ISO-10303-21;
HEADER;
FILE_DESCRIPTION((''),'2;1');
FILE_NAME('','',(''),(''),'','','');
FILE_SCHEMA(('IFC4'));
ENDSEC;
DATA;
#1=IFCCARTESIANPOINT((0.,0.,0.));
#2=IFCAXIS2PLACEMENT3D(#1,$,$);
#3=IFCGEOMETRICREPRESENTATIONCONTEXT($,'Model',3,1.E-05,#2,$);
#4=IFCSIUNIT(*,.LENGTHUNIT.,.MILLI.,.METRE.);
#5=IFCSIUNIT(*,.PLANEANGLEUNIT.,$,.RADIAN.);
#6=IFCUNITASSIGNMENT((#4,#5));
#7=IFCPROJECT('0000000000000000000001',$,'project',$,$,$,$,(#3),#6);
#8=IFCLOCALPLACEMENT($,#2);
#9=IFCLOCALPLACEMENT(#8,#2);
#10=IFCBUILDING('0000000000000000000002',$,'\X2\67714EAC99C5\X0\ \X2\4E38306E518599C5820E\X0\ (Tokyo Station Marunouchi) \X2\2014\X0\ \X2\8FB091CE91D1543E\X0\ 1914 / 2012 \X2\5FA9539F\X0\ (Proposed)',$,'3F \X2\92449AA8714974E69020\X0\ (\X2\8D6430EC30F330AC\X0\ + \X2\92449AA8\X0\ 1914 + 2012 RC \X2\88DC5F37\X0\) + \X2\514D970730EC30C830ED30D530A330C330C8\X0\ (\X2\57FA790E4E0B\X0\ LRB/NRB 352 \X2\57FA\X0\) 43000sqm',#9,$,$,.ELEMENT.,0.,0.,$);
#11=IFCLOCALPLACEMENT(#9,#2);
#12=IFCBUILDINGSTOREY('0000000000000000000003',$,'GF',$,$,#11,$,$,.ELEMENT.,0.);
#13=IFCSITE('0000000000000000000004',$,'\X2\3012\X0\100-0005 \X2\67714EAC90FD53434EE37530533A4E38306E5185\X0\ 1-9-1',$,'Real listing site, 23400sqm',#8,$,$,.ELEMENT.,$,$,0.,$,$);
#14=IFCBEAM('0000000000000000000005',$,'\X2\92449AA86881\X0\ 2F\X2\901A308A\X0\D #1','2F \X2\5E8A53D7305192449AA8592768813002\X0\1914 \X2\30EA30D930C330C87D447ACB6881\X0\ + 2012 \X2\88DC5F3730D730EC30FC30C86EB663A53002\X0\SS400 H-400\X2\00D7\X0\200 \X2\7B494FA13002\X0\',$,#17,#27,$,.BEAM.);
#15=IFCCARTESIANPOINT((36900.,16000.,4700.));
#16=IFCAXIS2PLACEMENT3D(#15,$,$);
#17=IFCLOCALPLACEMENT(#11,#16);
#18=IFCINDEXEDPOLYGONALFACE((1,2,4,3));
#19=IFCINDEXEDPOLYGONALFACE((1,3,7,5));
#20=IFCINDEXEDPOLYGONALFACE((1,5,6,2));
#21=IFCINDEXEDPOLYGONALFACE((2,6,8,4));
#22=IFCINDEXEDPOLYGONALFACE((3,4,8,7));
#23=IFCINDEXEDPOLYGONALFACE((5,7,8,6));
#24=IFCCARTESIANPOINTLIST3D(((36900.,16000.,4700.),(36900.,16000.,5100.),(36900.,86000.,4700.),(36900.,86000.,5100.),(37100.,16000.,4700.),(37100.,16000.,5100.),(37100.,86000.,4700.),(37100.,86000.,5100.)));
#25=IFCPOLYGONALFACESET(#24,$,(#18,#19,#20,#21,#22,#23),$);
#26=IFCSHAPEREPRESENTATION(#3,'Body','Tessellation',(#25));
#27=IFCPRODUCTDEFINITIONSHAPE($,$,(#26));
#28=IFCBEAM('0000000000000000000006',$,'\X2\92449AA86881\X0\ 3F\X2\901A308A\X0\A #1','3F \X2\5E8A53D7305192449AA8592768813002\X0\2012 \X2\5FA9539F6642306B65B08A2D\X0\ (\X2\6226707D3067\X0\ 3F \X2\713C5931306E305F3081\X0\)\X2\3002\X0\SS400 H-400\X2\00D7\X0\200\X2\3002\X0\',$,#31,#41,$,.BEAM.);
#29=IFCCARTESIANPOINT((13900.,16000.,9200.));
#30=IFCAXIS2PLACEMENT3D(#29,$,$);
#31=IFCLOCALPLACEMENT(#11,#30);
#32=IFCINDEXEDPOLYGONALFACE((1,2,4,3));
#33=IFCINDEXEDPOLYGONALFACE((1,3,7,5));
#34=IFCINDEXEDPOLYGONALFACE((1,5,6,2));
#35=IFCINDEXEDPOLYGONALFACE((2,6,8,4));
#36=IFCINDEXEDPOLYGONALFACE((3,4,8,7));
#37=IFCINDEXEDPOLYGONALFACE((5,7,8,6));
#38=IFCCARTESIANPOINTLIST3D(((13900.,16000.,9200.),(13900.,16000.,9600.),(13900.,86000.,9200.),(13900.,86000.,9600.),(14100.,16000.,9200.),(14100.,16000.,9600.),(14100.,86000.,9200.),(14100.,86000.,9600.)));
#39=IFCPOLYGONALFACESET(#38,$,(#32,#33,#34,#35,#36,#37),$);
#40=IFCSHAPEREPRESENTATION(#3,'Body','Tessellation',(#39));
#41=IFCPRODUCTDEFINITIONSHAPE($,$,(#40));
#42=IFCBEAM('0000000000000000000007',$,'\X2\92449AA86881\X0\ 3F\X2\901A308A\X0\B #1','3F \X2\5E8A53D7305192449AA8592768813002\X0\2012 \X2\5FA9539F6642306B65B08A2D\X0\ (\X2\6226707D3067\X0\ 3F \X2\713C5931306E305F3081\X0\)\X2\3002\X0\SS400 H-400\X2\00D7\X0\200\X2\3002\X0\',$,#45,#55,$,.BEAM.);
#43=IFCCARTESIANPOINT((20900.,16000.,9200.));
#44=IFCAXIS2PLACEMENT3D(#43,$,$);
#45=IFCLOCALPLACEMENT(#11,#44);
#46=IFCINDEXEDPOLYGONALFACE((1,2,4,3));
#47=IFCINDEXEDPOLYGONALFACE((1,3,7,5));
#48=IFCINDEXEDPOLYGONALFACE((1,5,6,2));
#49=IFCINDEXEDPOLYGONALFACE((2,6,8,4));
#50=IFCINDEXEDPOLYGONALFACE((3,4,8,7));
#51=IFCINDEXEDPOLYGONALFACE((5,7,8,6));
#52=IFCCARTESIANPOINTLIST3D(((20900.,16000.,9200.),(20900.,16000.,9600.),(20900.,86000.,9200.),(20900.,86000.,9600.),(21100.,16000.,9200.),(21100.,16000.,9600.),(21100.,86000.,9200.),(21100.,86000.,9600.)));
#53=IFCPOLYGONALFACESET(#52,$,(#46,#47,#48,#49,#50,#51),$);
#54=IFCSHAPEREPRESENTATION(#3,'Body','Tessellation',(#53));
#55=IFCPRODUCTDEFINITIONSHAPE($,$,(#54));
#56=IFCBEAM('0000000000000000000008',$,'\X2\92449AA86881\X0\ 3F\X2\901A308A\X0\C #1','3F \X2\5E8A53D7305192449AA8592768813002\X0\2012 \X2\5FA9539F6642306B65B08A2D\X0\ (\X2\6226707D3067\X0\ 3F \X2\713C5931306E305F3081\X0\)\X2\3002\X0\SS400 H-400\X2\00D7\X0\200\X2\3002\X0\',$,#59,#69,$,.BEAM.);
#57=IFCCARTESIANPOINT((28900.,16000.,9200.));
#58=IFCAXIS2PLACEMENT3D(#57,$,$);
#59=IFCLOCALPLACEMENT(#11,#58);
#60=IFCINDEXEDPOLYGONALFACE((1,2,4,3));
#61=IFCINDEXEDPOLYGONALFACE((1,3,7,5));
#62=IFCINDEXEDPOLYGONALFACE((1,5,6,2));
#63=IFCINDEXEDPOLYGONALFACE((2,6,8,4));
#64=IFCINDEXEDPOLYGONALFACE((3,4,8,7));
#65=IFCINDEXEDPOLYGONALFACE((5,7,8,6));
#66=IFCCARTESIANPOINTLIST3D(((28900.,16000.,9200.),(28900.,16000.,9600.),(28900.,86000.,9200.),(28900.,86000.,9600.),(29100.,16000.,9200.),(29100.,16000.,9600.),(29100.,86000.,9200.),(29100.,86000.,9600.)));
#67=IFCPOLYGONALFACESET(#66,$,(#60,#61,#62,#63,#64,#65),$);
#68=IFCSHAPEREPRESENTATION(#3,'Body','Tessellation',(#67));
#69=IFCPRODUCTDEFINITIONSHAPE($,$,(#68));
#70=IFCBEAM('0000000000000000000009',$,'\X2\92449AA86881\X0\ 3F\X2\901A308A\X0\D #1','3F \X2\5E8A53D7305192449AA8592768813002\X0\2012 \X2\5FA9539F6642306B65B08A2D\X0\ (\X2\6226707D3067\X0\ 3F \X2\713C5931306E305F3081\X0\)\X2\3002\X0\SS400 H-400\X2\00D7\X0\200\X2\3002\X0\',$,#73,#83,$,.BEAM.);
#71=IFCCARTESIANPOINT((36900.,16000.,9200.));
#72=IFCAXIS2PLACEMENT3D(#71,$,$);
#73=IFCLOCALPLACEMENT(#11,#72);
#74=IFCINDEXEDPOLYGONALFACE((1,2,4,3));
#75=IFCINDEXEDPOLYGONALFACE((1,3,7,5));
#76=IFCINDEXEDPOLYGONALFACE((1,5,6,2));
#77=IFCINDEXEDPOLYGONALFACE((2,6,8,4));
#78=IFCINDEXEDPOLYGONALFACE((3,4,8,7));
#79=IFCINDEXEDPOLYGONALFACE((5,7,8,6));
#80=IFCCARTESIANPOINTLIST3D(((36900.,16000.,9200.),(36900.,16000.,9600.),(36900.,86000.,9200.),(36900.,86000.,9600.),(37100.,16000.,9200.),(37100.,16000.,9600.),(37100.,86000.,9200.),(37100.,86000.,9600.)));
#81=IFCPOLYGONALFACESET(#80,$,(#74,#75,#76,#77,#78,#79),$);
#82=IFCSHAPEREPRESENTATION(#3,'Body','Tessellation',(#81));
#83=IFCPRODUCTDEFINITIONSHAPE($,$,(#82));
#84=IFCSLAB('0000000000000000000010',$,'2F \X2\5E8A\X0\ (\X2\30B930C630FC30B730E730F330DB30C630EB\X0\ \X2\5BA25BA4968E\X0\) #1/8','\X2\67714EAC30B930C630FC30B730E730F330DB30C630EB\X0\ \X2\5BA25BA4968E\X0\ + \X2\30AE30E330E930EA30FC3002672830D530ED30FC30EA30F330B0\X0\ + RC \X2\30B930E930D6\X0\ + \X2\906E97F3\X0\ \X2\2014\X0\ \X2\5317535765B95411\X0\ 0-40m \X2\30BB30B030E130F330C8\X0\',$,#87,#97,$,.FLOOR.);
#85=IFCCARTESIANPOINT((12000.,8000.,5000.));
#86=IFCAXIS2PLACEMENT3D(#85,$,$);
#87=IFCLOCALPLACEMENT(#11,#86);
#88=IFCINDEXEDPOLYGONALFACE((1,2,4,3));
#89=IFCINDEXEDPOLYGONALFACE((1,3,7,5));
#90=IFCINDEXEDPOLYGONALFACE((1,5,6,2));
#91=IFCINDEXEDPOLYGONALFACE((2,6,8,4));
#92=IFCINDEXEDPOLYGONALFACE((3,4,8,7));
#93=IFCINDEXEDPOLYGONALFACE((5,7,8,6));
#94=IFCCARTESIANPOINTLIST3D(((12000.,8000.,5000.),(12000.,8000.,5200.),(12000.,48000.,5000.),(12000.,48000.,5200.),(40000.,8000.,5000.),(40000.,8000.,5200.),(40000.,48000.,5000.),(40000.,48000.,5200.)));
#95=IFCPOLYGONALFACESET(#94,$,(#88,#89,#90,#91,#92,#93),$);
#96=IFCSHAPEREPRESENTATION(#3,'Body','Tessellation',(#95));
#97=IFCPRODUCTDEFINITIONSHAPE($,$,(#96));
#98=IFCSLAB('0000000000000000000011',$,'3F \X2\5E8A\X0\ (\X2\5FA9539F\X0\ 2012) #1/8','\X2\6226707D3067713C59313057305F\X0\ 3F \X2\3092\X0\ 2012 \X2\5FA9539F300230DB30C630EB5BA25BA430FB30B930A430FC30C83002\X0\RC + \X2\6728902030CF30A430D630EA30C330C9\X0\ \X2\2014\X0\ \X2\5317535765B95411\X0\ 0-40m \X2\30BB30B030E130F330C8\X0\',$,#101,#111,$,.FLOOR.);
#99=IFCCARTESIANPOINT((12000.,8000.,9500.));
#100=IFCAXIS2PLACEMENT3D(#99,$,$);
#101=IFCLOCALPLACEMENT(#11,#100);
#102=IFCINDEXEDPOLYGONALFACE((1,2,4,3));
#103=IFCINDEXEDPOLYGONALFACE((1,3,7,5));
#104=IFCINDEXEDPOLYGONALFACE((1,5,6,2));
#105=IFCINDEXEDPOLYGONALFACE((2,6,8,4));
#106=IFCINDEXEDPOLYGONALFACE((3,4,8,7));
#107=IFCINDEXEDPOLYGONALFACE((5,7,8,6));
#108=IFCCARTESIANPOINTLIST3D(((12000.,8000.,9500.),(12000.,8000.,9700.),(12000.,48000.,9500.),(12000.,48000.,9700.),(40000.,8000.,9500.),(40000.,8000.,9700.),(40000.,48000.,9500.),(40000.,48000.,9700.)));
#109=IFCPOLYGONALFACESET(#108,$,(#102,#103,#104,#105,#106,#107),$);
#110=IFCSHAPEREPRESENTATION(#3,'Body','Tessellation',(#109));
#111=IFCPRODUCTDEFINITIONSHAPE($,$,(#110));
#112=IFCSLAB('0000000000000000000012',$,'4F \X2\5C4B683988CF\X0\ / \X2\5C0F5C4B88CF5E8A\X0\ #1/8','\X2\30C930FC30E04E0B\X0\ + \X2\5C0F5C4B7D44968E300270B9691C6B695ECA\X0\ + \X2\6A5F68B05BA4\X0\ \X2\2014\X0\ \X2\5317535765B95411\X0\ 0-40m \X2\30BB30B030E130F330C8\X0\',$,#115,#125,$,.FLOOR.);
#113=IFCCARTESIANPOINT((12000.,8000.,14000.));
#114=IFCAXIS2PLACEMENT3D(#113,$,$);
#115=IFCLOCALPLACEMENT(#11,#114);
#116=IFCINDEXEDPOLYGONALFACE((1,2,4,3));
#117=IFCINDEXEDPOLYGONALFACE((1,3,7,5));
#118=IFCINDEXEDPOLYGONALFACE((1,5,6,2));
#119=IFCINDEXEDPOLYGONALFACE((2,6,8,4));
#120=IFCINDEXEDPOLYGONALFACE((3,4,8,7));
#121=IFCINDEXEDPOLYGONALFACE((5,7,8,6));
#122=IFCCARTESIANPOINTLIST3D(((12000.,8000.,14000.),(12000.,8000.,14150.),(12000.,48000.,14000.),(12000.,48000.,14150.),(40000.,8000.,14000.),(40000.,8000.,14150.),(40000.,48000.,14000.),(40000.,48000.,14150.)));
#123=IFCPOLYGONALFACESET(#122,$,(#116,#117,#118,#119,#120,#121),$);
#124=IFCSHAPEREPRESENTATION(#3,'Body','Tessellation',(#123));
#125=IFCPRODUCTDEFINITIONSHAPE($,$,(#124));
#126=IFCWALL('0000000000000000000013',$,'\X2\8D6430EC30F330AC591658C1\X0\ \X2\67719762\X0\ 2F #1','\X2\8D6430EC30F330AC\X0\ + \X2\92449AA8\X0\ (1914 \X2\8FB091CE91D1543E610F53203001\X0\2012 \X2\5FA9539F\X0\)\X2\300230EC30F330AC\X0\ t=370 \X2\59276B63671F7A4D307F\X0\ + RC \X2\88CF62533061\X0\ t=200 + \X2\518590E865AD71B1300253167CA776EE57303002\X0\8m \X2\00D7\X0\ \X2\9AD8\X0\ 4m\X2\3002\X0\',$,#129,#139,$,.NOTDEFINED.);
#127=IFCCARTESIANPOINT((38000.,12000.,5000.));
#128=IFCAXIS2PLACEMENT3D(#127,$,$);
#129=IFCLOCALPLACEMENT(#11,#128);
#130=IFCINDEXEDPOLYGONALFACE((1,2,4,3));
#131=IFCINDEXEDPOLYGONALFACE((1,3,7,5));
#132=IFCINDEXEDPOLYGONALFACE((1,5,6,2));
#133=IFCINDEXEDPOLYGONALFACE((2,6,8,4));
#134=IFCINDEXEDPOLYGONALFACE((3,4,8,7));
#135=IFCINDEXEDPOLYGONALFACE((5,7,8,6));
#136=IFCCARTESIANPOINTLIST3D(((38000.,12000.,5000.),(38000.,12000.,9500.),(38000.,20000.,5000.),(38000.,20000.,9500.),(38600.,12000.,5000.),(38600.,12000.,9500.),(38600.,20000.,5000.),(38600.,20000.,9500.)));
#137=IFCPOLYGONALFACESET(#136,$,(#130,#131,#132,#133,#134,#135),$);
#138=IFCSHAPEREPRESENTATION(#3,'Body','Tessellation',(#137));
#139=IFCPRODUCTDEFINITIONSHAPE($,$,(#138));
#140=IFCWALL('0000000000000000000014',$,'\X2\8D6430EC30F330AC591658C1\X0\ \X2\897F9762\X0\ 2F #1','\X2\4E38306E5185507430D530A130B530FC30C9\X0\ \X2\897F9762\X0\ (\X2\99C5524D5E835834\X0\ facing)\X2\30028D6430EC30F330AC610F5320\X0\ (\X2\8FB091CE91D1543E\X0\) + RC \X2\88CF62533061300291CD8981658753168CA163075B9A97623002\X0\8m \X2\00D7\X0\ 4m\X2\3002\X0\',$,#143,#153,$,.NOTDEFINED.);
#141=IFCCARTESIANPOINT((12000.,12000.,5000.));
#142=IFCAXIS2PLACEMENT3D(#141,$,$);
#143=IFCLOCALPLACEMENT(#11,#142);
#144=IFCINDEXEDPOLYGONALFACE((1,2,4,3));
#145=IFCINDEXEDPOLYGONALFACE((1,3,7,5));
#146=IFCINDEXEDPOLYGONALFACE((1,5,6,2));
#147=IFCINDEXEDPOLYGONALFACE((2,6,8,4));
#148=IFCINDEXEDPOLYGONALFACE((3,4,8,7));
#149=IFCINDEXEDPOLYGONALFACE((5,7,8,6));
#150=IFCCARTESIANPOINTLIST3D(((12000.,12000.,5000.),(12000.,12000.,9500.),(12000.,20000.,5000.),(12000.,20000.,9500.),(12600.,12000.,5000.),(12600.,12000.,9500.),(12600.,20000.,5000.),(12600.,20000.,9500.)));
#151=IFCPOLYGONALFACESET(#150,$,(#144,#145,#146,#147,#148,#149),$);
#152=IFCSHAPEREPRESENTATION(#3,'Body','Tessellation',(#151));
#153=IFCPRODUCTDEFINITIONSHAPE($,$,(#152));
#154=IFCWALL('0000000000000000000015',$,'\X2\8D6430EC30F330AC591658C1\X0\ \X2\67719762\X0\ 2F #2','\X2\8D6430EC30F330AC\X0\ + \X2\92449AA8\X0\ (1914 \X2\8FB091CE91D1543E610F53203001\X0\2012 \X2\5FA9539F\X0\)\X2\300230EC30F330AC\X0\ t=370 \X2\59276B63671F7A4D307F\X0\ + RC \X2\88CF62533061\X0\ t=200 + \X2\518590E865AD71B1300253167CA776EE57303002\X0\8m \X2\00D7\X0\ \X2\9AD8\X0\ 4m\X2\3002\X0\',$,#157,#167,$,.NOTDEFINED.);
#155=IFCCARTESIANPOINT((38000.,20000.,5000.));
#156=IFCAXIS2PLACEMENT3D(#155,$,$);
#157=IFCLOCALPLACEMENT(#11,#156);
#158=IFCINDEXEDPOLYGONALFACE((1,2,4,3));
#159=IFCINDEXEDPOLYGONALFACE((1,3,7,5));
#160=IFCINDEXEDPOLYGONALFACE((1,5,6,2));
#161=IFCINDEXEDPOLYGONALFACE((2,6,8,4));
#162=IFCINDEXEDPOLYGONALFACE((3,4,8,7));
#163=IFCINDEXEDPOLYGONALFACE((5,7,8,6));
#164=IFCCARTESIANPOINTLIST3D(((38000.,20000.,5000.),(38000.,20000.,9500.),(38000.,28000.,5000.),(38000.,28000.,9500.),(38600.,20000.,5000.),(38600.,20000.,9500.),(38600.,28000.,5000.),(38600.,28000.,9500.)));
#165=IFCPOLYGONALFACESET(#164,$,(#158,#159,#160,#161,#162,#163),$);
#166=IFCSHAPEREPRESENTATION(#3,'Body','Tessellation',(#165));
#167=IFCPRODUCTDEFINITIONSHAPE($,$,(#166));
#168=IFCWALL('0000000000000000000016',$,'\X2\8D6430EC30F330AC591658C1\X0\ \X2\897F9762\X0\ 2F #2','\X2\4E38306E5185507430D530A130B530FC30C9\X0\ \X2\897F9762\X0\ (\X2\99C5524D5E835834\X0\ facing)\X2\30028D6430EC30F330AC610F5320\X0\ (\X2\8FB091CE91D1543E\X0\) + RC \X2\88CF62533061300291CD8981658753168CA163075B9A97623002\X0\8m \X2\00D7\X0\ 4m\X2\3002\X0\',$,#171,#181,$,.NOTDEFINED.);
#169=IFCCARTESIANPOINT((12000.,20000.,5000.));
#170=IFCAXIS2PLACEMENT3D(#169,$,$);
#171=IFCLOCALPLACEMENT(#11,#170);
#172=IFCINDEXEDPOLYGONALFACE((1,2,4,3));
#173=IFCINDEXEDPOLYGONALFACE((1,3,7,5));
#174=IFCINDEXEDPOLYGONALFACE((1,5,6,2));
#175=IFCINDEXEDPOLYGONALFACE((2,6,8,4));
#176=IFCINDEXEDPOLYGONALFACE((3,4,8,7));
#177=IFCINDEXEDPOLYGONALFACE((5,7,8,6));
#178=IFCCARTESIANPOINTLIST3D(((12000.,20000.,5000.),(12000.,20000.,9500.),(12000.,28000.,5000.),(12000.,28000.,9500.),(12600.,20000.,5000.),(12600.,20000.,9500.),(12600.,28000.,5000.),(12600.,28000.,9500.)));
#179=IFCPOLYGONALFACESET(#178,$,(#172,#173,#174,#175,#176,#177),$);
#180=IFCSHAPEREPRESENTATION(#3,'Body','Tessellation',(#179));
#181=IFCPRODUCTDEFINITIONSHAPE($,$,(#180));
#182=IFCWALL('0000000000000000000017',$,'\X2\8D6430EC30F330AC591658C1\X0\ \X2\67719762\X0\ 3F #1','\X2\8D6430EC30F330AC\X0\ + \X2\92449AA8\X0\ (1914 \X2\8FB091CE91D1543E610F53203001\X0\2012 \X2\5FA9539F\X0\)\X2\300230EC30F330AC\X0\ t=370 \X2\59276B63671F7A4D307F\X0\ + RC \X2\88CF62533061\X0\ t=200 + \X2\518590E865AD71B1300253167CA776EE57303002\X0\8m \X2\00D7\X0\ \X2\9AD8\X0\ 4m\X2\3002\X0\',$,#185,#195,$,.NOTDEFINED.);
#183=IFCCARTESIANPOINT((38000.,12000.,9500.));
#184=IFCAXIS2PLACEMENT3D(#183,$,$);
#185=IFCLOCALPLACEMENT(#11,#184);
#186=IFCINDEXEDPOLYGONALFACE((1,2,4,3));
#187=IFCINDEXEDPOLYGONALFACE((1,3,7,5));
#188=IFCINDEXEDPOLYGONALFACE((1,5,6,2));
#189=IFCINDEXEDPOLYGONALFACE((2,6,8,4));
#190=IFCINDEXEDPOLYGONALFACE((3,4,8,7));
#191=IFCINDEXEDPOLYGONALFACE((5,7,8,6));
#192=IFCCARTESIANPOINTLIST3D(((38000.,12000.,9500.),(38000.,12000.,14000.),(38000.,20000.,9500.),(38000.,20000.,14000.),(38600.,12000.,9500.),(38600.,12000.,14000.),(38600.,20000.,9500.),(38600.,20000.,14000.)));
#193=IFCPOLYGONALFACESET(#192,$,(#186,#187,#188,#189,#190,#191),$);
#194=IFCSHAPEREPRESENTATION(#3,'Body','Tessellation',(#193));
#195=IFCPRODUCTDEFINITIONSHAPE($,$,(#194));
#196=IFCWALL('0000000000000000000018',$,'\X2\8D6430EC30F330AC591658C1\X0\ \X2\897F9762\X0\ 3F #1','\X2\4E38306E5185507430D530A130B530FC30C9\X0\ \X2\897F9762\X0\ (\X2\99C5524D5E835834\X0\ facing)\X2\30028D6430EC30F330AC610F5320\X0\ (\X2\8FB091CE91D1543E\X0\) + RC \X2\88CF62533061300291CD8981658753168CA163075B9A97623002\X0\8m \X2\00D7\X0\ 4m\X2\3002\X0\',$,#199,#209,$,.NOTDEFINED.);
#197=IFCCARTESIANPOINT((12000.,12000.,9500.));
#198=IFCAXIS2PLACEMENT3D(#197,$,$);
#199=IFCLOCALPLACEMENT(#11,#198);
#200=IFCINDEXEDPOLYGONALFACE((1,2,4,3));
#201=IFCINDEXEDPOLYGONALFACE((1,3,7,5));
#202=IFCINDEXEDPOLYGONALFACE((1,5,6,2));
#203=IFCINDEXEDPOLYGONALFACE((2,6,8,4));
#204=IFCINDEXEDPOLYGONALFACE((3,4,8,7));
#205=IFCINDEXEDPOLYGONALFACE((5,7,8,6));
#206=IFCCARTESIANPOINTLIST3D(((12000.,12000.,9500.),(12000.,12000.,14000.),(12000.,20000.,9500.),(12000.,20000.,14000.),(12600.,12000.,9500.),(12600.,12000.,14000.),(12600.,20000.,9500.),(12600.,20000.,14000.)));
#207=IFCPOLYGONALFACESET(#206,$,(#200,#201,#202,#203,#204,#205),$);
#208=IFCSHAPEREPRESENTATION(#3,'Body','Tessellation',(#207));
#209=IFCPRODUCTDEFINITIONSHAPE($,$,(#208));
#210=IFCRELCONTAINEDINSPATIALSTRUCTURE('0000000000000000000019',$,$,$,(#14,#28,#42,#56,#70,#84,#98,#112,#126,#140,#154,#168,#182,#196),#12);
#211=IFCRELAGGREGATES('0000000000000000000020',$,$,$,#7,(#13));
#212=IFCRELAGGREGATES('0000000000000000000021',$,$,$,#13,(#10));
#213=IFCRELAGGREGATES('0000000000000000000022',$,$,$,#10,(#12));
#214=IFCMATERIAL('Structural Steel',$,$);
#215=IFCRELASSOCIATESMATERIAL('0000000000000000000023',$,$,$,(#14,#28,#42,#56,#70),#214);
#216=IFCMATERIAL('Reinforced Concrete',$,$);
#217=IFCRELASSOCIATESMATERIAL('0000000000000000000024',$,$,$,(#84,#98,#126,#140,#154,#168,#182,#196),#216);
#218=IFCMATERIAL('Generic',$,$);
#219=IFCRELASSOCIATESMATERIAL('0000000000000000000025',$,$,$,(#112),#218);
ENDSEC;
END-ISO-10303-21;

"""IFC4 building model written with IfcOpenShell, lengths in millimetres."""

from ifc_helpers import new_model, si_unit, frame, frame_2d, origin, place, context, project, spatial, rectangle, extrude, material, element, save


model = new_model("IFC4")

# Units and contexts
model_context = context("Model", 3, precision=1e-05, world=origin())
ifc_project = project(units=[si_unit("LENGTHUNIT", "METRE", prefix="MILLI"), si_unit("PLANEANGLEUNIT", "RADIAN")], contexts=[model_context])

# Site, building, storey
site_placement = place(None, origin())
site = spatial("IfcSite", under=ifc_project, at=site_placement, Name="〒100-0005 東京都千代田区丸の内 1-9-1", ObjectType="Real listing site, 23400sqm", CompositionType="ELEMENT", RefElevation=0.0)
building_placement = place(site_placement, origin())
building = spatial("IfcBuilding", under=site, at=building_placement, Name="東京駅 丸の内駅舎 (Tokyo Station Marunouchi) — 辰野金吾 1914 / 2012 復原 (Proposed)", ObjectType="3F 鉄骨煉瓦造 (赤レンガ + 鉄骨 1914 + 2012 RC 補強) + 免震レトロフィット (基礎下 LRB/NRB 352 基) 43000sqm", CompositionType="ELEMENT", ElevationOfRefHeight=0.0, ElevationOfTerrain=0.0)
storey_placement = place(building_placement, origin())
storey = spatial("IfcBuildingStorey", under=building, at=storey_placement, Name="GF", CompositionType="ELEMENT", Elevation=0.0)

# Beams
ifc_material_1 = material(Name="Structural Steel")
beam_1_placement = place(storey_placement, frame((36900.0, 16000.0, 4700.0)))
element("IfcBeam", 1, at=beam_1_placement, inside=storey, material=ifc_material_1, Name="鉄骨梁 2F通りD #1", Description="2F 床受け鉄骨大梁。1914 リベット組立梁 + 2012 補強プレート溶接。SS400 H-400×200 等価。", PredefinedType="BEAM", context=model_context, shape_type="SweptSolid", body=[
    extrude(rectangle(XDim=200.0, YDim=70000.0, at=frame_2d((100.0, 35000.0))), frame((36900.0, 16000.0, 4700.0)), (0.0, 0.0, 1.0), 400.0),
])
beam_2_placement = place(storey_placement, frame((13900.0, 16000.0, 9200.0)))
element("IfcBeam", 2, at=beam_2_placement, inside=storey, material=ifc_material_1, Name="鉄骨梁 3F通りA #1", Description="3F 床受け鉄骨大梁。2012 復原時に新設 (戦災で 3F 焼失のため)。SS400 H-400×200。", PredefinedType="BEAM", context=model_context, shape_type="SweptSolid", body=[
    extrude(rectangle(XDim=200.0, YDim=70000.0, at=frame_2d((100.0, 35000.0))), frame((13900.0, 16000.0, 9200.0)), (0.0, 0.0, 1.0), 400.0),
])
beam_3_placement = place(storey_placement, frame((20900.0, 16000.0, 9200.0)))
element("IfcBeam", 3, at=beam_3_placement, inside=storey, material=ifc_material_1, Name="鉄骨梁 3F通りB #1", Description="3F 床受け鉄骨大梁。2012 復原時に新設 (戦災で 3F 焼失のため)。SS400 H-400×200。", PredefinedType="BEAM", context=model_context, shape_type="SweptSolid", body=[
    extrude(rectangle(XDim=200.0, YDim=70000.0, at=frame_2d((100.0, 35000.0))), frame((20900.0, 16000.0, 9200.0)), (0.0, 0.0, 1.0), 400.0),
])
beam_4_placement = place(storey_placement, frame((28900.0, 16000.0, 9200.0)))
element("IfcBeam", 4, at=beam_4_placement, inside=storey, material=ifc_material_1, Name="鉄骨梁 3F通りC #1", Description="3F 床受け鉄骨大梁。2012 復原時に新設 (戦災で 3F 焼失のため)。SS400 H-400×200。", PredefinedType="BEAM", context=model_context, shape_type="SweptSolid", body=[
    extrude(rectangle(XDim=200.0, YDim=70000.0, at=frame_2d((100.0, 35000.0))), frame((28900.0, 16000.0, 9200.0)), (0.0, 0.0, 1.0), 400.0),
])
beam_5_placement = place(storey_placement, frame((36900.0, 16000.0, 9200.0)))
element("IfcBeam", 5, at=beam_5_placement, inside=storey, material=ifc_material_1, Name="鉄骨梁 3F通りD #1", Description="3F 床受け鉄骨大梁。2012 復原時に新設 (戦災で 3F 焼失のため)。SS400 H-400×200。", PredefinedType="BEAM", context=model_context, shape_type="SweptSolid", body=[
    extrude(rectangle(XDim=200.0, YDim=70000.0, at=frame_2d((100.0, 35000.0))), frame((36900.0, 16000.0, 9200.0)), (0.0, 0.0, 1.0), 400.0),
])

# Slabs
ifc_material_2 = material(Name="Reinforced Concrete")
slab_1_placement = place(storey_placement, frame((12000.0, 8000.0, 5000.0)))
element("IfcSlab", 6, at=slab_1_placement, inside=storey, material=ifc_material_2, Name="2F 床 (ステーションホテル 客室階) #1/8", Description="東京ステーションホテル 客室階 + ギャラリー。木フローリング + RC スラブ + 遮音 — 北南方向 0-40m セグメント", PredefinedType="FLOOR", context=model_context, shape_type="SweptSolid", body=[
    extrude(rectangle(XDim=28000.0, YDim=40000.0, at=frame_2d((14000.0, 20000.0))), frame((12000.0, 8000.0, 5000.0)), (0.0, 0.0, 1.0), 200.0),
])
slab_2_placement = place(storey_placement, frame((12000.0, 8000.0, 9500.0)))
element("IfcSlab", 7, at=slab_2_placement, inside=storey, material=ifc_material_2, Name="3F 床 (復原 2012) #1/8", Description="戦災で焼失した 3F を 2012 復原。ホテル客室・スイート。RC + 木造ハイブリッド — 北南方向 0-40m セグメント", PredefinedType="FLOOR", context=model_context, shape_type="SweptSolid", body=[
    extrude(rectangle(XDim=28000.0, YDim=40000.0, at=frame_2d((14000.0, 20000.0))), frame((12000.0, 8000.0, 9500.0)), (0.0, 0.0, 1.0), 200.0),
])
ifc_material_3 = material(Name="Generic")
slab_3_placement = place(storey_placement, frame((12000.0, 8000.0, 14000.0)))
element("IfcSlab", 8, at=slab_3_placement, inside=storey, material=ifc_material_3, Name="4F 屋根裏 / 小屋裏床 #1/8", Description="ドーム下 + 小屋組階。点検歩廊 + 機械室 — 北南方向 0-40m セグメント", PredefinedType="FLOOR", context=model_context, shape_type="SweptSolid", body=[
    extrude(rectangle(XDim=28000.0, YDim=40000.0, at=frame_2d((14000.0, 20000.0))), frame((12000.0, 8000.0, 14000.0)), (0.0, 0.0, 1.0), 150.0),
])

# Walls
wall_1_placement = place(storey_placement, frame((38000.0, 12000.0, 5000.0)))
element("IfcWall", 9, at=wall_1_placement, inside=storey, material=ifc_material_2, Name="赤レンガ外壁 東面 2F #1", Description="赤レンガ + 鉄骨 (1914 辰野金吾意匠、2012 復原)。レンガ t=370 大正期積み + RC 裏打ち t=200 + 内部断熱。化粧目地。8m × 高 4m。", PredefinedType="NOTDEFINED", context=model_context, shape_type="SweptSolid", body=[
    extrude(rectangle(XDim=600.0, YDim=8000.0, at=frame_2d((300.0, 4000.0))), frame((38000.0, 12000.0, 5000.0)), (0.0, 0.0, 1.0), 4500.0),
])
wall_2_placement = place(storey_placement, frame((12000.0, 12000.0, 5000.0)))
element("IfcWall", 10, at=wall_2_placement, inside=storey, material=ifc_material_2, Name="赤レンガ外壁 西面 2F #1", Description="丸の内側ファサード 西面 (駅前広場 facing)。赤レンガ意匠 (辰野金吾) + RC 裏打ち。重要文化財指定面。8m × 4m。", PredefinedType="NOTDEFINED", context=model_context, shape_type="SweptSolid", body=[
    extrude(rectangle(XDim=600.0, YDim=8000.0, at=frame_2d((300.0, 4000.0))), frame((12000.0, 12000.0, 5000.0)), (0.0, 0.0, 1.0), 4500.0),
])
wall_3_placement = place(storey_placement, frame((38000.0, 20000.0, 5000.0)))
element("IfcWall", 11, at=wall_3_placement, inside=storey, material=ifc_material_2, Name="赤レンガ外壁 東面 2F #2", Description="赤レンガ + 鉄骨 (1914 辰野金吾意匠、2012 復原)。レンガ t=370 大正期積み + RC 裏打ち t=200 + 内部断熱。化粧目地。8m × 高 4m。", PredefinedType="NOTDEFINED", context=model_context, shape_type="SweptSolid", body=[
    extrude(rectangle(XDim=600.0, YDim=8000.0, at=frame_2d((300.0, 4000.0))), frame((38000.0, 20000.0, 5000.0)), (0.0, 0.0, 1.0), 4500.0),
])
wall_4_placement = place(storey_placement, frame((12000.0, 20000.0, 5000.0)))
element("IfcWall", 12, at=wall_4_placement, inside=storey, material=ifc_material_2, Name="赤レンガ外壁 西面 2F #2", Description="丸の内側ファサード 西面 (駅前広場 facing)。赤レンガ意匠 (辰野金吾) + RC 裏打ち。重要文化財指定面。8m × 4m。", PredefinedType="NOTDEFINED", context=model_context, shape_type="SweptSolid", body=[
    extrude(rectangle(XDim=600.0, YDim=8000.0, at=frame_2d((300.0, 4000.0))), frame((12000.0, 20000.0, 5000.0)), (0.0, 0.0, 1.0), 4500.0),
])
wall_5_placement = place(storey_placement, frame((38000.0, 12000.0, 9500.0)))
element("IfcWall", 13, at=wall_5_placement, inside=storey, material=ifc_material_2, Name="赤レンガ外壁 東面 3F #1", Description="赤レンガ + 鉄骨 (1914 辰野金吾意匠、2012 復原)。レンガ t=370 大正期積み + RC 裏打ち t=200 + 内部断熱。化粧目地。8m × 高 4m。", PredefinedType="NOTDEFINED", context=model_context, shape_type="SweptSolid", body=[
    extrude(rectangle(XDim=600.0, YDim=8000.0, at=frame_2d((300.0, 4000.0))), frame((38000.0, 12000.0, 9500.0)), (0.0, 0.0, 1.0), 4500.0),
])
wall_6_placement = place(storey_placement, frame((12000.0, 12000.0, 9500.0)))
element("IfcWall", 14, at=wall_6_placement, inside=storey, material=ifc_material_2, Name="赤レンガ外壁 西面 3F #1", Description="丸の内側ファサード 西面 (駅前広場 facing)。赤レンガ意匠 (辰野金吾) + RC 裏打ち。重要文化財指定面。8m × 4m。", PredefinedType="NOTDEFINED", context=model_context, shape_type="SweptSolid", body=[
    extrude(rectangle(XDim=600.0, YDim=8000.0, at=frame_2d((300.0, 4000.0))), frame((12000.0, 12000.0, 9500.0)), (0.0, 0.0, 1.0), 4500.0),
])

save(model, "model.ifc")
